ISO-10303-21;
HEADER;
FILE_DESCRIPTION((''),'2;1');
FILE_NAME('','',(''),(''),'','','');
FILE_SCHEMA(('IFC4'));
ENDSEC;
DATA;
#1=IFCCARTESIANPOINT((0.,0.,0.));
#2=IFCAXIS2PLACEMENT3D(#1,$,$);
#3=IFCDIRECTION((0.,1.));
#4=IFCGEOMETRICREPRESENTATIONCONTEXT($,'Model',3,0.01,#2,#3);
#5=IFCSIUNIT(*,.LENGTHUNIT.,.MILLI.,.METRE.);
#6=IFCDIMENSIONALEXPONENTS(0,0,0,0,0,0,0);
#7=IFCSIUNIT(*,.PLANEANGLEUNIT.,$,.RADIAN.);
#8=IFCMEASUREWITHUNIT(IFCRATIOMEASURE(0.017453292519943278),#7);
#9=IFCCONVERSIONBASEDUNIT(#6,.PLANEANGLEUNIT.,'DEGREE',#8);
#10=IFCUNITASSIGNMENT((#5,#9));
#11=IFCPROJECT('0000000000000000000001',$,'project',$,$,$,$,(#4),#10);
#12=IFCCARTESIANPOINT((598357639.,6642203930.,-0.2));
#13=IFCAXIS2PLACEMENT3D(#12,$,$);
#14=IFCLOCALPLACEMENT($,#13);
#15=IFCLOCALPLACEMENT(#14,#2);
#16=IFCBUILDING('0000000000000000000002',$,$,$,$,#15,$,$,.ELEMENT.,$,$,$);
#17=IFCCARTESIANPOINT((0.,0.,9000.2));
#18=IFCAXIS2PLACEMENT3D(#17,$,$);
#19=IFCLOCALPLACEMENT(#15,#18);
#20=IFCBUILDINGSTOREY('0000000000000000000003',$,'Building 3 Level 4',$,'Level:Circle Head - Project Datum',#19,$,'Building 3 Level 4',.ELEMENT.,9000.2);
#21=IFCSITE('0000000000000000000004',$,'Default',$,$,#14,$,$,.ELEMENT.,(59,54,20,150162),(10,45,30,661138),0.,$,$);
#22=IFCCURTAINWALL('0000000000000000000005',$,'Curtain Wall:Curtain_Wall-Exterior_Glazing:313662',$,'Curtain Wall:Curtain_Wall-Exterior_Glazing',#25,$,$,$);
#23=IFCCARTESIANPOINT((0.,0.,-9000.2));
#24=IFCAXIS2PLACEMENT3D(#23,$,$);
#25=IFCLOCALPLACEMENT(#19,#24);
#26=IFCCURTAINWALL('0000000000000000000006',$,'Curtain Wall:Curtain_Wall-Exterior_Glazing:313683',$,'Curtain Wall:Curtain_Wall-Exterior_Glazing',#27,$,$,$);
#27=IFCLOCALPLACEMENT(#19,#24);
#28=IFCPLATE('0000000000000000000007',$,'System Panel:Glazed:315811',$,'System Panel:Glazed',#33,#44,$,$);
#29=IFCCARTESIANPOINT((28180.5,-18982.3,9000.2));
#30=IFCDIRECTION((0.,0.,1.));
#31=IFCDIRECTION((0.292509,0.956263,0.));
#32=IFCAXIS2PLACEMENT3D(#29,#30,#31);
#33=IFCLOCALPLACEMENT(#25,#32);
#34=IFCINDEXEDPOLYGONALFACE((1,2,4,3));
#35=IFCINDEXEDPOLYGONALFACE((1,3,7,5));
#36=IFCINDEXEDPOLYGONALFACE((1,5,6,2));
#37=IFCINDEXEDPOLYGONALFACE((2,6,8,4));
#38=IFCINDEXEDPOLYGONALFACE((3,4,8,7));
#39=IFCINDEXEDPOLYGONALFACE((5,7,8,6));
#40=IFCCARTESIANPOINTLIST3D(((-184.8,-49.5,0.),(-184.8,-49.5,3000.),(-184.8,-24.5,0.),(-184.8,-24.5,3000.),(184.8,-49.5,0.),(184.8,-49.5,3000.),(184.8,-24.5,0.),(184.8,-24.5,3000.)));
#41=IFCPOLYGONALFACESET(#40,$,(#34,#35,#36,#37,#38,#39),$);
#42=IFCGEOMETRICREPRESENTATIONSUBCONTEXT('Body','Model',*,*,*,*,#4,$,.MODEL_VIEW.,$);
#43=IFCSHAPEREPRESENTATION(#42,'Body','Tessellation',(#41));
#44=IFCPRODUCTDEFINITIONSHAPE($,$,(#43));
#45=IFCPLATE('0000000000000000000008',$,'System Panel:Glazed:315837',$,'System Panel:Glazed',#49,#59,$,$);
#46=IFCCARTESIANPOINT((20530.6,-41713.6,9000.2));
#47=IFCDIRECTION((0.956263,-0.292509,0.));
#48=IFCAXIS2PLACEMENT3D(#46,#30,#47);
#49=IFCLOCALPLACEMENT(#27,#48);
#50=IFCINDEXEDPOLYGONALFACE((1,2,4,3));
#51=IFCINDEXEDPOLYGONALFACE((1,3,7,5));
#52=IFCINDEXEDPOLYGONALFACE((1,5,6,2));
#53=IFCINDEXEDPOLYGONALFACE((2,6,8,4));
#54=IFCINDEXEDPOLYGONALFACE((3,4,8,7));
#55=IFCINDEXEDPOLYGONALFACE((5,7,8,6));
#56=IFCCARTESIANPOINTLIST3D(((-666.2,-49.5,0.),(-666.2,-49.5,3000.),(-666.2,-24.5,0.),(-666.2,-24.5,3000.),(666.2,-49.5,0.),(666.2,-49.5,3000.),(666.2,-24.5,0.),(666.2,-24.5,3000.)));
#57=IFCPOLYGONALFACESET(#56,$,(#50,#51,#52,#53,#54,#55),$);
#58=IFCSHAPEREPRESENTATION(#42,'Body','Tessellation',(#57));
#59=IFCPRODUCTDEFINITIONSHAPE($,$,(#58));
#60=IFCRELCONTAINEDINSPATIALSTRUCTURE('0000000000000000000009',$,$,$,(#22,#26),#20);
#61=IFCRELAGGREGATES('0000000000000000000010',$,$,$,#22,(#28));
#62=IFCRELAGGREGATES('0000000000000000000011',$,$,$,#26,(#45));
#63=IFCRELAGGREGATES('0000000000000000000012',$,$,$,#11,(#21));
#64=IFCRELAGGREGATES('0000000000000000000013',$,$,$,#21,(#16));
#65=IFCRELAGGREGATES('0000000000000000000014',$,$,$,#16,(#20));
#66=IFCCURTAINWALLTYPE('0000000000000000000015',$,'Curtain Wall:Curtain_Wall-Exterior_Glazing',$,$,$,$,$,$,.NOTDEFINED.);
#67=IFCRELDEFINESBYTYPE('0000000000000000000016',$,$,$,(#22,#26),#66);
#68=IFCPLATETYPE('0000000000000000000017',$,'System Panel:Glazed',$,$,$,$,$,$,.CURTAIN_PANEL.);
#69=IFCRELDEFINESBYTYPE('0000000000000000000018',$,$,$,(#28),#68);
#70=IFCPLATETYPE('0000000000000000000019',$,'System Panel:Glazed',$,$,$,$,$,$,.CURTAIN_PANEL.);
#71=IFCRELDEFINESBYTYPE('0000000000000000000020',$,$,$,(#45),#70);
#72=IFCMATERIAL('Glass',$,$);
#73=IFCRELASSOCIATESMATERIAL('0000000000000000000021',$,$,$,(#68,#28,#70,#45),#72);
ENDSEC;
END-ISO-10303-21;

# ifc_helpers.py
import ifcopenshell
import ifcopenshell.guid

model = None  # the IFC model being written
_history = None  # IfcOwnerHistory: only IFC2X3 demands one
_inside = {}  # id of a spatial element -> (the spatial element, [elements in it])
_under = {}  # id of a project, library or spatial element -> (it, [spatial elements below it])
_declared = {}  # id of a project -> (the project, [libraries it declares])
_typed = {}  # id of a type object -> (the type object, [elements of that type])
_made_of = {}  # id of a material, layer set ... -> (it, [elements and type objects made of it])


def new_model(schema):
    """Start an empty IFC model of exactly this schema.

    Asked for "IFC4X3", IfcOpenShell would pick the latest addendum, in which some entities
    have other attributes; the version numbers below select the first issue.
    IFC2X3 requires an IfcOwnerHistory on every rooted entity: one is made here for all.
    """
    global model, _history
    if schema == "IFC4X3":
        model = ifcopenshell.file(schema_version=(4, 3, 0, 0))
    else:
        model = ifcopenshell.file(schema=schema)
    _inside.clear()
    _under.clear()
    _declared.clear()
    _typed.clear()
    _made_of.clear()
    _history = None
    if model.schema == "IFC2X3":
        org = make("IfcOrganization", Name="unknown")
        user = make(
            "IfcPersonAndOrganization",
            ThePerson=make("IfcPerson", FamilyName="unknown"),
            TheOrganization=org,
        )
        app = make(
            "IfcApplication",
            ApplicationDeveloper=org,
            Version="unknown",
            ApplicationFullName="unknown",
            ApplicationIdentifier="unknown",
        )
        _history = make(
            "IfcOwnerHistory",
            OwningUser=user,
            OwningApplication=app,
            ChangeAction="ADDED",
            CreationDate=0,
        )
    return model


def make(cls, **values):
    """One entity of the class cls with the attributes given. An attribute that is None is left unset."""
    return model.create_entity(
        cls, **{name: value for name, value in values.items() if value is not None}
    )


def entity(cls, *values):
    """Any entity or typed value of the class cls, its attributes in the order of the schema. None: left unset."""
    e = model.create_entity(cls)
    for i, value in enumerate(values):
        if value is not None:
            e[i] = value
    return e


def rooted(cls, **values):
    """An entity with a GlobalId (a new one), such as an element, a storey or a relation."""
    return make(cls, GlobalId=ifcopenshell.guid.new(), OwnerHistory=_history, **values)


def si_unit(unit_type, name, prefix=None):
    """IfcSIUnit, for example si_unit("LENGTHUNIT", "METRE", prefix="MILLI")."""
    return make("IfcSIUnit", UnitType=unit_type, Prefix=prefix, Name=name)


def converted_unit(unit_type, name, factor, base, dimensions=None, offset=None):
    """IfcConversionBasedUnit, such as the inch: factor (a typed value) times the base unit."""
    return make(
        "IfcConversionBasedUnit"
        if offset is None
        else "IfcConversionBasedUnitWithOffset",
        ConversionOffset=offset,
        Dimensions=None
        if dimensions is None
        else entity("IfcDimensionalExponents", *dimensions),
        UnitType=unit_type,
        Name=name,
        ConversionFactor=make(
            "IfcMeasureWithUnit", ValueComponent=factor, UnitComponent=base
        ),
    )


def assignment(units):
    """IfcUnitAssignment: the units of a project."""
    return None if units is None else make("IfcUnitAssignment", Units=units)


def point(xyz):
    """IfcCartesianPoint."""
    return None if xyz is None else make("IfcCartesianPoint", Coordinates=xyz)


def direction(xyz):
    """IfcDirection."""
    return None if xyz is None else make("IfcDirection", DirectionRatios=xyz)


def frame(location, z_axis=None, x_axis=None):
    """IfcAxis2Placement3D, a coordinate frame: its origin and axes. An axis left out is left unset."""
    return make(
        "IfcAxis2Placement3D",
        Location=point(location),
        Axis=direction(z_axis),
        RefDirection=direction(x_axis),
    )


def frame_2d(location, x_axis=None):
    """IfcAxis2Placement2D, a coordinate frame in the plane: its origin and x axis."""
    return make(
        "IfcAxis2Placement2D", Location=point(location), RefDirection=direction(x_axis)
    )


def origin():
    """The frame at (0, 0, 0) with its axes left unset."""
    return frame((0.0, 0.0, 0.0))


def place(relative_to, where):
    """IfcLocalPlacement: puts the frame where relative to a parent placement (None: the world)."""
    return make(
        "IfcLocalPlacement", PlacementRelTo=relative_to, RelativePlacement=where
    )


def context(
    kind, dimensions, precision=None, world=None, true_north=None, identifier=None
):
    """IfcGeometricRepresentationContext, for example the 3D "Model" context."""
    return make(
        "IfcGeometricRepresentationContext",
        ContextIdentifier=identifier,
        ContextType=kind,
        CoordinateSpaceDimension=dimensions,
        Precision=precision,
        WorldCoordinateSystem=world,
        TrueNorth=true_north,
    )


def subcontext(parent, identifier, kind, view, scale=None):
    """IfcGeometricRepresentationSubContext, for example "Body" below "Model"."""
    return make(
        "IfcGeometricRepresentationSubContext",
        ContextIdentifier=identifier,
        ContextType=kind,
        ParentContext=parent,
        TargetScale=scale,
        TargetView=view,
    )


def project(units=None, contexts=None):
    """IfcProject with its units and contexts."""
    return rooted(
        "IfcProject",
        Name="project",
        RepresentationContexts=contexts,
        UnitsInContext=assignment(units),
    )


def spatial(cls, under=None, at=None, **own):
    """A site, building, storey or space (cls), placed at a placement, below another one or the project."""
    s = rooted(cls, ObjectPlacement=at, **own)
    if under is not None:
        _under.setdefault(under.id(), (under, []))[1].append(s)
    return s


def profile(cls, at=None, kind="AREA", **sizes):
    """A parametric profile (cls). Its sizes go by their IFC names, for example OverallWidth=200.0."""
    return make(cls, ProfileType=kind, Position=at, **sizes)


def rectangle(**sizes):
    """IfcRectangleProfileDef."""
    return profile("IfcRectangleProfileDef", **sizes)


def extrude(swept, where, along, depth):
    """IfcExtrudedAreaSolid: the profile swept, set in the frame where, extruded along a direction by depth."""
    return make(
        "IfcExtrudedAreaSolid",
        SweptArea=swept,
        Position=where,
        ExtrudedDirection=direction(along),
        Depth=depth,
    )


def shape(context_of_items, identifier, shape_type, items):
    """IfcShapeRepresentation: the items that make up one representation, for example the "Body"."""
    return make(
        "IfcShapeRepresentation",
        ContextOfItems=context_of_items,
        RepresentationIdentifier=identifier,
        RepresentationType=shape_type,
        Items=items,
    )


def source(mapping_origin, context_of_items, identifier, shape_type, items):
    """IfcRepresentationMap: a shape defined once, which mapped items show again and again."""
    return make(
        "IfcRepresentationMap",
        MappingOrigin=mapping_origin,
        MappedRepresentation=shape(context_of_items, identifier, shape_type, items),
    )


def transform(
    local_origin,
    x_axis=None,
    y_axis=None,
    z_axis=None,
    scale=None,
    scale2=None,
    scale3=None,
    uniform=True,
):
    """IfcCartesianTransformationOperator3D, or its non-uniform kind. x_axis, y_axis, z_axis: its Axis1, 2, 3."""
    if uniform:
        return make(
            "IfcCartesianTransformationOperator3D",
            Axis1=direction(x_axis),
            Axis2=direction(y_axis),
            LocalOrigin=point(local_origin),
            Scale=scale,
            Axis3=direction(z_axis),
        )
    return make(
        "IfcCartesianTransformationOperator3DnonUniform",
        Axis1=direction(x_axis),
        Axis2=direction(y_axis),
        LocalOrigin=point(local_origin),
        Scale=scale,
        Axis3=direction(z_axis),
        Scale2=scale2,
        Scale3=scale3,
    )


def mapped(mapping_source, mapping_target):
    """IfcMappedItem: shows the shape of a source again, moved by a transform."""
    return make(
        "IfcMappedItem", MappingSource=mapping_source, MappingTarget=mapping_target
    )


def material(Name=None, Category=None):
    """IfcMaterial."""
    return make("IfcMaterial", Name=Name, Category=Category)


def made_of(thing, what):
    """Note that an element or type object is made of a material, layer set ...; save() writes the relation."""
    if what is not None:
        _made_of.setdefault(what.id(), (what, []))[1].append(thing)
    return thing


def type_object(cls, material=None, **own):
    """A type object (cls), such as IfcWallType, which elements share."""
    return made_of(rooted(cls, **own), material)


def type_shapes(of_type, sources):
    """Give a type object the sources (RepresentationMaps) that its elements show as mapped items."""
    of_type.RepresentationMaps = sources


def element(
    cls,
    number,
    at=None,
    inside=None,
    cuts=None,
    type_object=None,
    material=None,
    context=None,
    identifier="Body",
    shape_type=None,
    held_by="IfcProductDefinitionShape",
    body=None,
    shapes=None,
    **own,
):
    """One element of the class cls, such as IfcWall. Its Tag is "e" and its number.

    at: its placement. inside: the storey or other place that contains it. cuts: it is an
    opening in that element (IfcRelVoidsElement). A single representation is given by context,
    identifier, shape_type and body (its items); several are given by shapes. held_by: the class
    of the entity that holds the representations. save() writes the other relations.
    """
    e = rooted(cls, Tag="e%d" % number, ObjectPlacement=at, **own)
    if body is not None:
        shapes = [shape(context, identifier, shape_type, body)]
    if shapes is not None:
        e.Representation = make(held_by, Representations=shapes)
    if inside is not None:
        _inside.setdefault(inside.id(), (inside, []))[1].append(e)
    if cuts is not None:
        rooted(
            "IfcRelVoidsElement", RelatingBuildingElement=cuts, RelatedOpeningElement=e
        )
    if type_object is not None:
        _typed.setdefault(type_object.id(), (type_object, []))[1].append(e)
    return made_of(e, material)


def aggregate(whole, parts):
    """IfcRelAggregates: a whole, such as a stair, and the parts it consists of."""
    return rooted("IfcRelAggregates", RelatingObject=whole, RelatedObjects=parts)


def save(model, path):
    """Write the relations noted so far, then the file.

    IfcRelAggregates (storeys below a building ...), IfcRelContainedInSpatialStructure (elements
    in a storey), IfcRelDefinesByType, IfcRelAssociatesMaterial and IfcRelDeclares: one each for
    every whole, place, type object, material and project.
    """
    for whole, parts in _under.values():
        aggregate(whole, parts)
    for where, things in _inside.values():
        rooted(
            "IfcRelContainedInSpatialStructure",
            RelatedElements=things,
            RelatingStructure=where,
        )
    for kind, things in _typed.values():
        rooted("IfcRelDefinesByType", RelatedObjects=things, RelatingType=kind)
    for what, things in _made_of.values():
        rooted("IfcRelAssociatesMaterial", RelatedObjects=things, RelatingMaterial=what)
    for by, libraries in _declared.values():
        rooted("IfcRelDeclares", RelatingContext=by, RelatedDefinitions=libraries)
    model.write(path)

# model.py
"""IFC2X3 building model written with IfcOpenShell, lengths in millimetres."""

from ifc_helpers import new_model, entity, si_unit, converted_unit, direction, frame, frame_2d, origin, place, context, subcontext, project, spatial, rectangle, extrude, source, transform, mapped, material, type_object, type_shapes, element, aggregate, save


model = new_model("IFC2X3")

# Units and contexts
model_context = context("Model", 3, precision=0.01, world=origin(), true_north=direction((0.0, 1.0)))
body_context = subcontext(model_context, "Body", "Model", "MODEL_VIEW")
ifc_project = project(units=[si_unit("LENGTHUNIT", "METRE", prefix="MILLI"), converted_unit("PLANEANGLEUNIT", "DEGREE", entity("IfcRatioMeasure", 0.017453292519943278), si_unit("PLANEANGLEUNIT", "RADIAN"), dimensions=[0, 0, 0, 0, 0, 0, 0])], contexts=[model_context])

# Site, building, storey
site_placement = place(None, frame((598357639.0, 6642203930.0, -0.2)))
site = spatial("IfcSite", under=ifc_project, at=site_placement, Name="Default", CompositionType="ELEMENT", RefLatitude=(59, 54, 20, 150162), RefLongitude=(10, 45, 30, 661138), RefElevation=0.0)
building_placement = place(site_placement, origin())
building = spatial("IfcBuilding", under=site, at=building_placement, CompositionType="ELEMENT")
storey_placement = place(building_placement, frame((0.0, 0.0, 9000.2)))
storey = spatial("IfcBuildingStorey", under=building, at=storey_placement, Name="Building 3 Level 4", ObjectType="Level:Circle Head - Project Datum", LongName="Building 3 Level 4", CompositionType="ELEMENT", Elevation=9000.2)

# Curtain walls
curtain_wall_type = type_object("IfcCurtainWallType", Name="Curtain Wall:Curtain_Wall-Exterior_Glazing", PredefinedType="NOTDEFINED")
curtain_wall_1_placement = place(storey_placement, frame((0.0, 0.0, -9000.2)))
curtain_wall_1 = element("IfcCurtainWall", 1, at=curtain_wall_1_placement, inside=storey, type_object=curtain_wall_type, Name="Curtain Wall:Curtain_Wall-Exterior_Glazing:313662", ObjectType="Curtain Wall:Curtain_Wall-Exterior_Glazing")
ifc_material_1 = material(Name="Glass")
curtain_wall_2_placement = place(storey_placement, frame((0.0, 0.0, -9000.2)))
curtain_wall_2 = element("IfcCurtainWall", 2, at=curtain_wall_2_placement, inside=storey, type_object=curtain_wall_type, Name="Curtain Wall:Curtain_Wall-Exterior_Glazing:313683", ObjectType="Curtain Wall:Curtain_Wall-Exterior_Glazing")

# Plates
plate_type_1 = type_object("IfcPlateType", Name="System Panel:Glazed", PredefinedType="CURTAIN_PANEL", material=ifc_material_1)
shared_shape_1 = source(origin(), body_context, "Body", "SweptSolid", [
    extrude(rectangle(XDim=25.0, YDim=369.6, at=frame_2d((0.0, 0.0), x_axis=(1.0, 0.0))), frame((0.0, -37.0, 0.0), z_axis=(0.0, 0.0, 1.0), x_axis=(0.0, 1.0, 0.0)), (0.0, 0.0, 1.0), 3000.0),
])
type_shapes(plate_type_1, [shared_shape_1])
plate_1_placement = place(curtain_wall_1_placement, frame((28180.5, -18982.3, 9000.2), z_axis=(0.0, 0.0, 1.0), x_axis=(0.292509, 0.956263, 0.0)))
plate_1 = element("IfcPlate", 3, at=plate_1_placement, type_object=plate_type_1, material=ifc_material_1, Name="System Panel:Glazed:315811", ObjectType="System Panel:Glazed", context=body_context, shape_type="MappedRepresentation", body=[
    mapped(shared_shape_1, transform((0.0, 0.0, 0.0), scale=1.0)),
])
aggregate(curtain_wall_1, [plate_1])
plate_type_2 = type_object("IfcPlateType", Name="System Panel:Glazed", PredefinedType="CURTAIN_PANEL", material=ifc_material_1)
shared_shape_2 = source(origin(), body_context, "Body", "SweptSolid", [
    extrude(rectangle(XDim=25.0, YDim=1332.3, at=frame_2d((0.0, 0.0), x_axis=(1.0, 0.0))), frame((0.0, -37.0, 0.0), z_axis=(0.0, 0.0, 1.0), x_axis=(0.0, 1.0, 0.0)), (0.0, 0.0, 1.0), 3000.0),
])
type_shapes(plate_type_2, [shared_shape_2])
plate_2_placement = place(curtain_wall_2_placement, frame((20530.6, -41713.6, 9000.2), z_axis=(0.0, 0.0, 1.0), x_axis=(0.956263, -0.292509, 0.0)))
plate_2 = element("IfcPlate", 4, at=plate_2_placement, type_object=plate_type_2, material=ifc_material_1, Name="System Panel:Glazed:315837", ObjectType="System Panel:Glazed", context=body_context, shape_type="MappedRepresentation", body=[
    mapped(shared_shape_2, transform((0.0, 0.0, 0.0), scale=1.0)),
])
aggregate(curtain_wall_2, [plate_2])

save(model, "model.ifc")
